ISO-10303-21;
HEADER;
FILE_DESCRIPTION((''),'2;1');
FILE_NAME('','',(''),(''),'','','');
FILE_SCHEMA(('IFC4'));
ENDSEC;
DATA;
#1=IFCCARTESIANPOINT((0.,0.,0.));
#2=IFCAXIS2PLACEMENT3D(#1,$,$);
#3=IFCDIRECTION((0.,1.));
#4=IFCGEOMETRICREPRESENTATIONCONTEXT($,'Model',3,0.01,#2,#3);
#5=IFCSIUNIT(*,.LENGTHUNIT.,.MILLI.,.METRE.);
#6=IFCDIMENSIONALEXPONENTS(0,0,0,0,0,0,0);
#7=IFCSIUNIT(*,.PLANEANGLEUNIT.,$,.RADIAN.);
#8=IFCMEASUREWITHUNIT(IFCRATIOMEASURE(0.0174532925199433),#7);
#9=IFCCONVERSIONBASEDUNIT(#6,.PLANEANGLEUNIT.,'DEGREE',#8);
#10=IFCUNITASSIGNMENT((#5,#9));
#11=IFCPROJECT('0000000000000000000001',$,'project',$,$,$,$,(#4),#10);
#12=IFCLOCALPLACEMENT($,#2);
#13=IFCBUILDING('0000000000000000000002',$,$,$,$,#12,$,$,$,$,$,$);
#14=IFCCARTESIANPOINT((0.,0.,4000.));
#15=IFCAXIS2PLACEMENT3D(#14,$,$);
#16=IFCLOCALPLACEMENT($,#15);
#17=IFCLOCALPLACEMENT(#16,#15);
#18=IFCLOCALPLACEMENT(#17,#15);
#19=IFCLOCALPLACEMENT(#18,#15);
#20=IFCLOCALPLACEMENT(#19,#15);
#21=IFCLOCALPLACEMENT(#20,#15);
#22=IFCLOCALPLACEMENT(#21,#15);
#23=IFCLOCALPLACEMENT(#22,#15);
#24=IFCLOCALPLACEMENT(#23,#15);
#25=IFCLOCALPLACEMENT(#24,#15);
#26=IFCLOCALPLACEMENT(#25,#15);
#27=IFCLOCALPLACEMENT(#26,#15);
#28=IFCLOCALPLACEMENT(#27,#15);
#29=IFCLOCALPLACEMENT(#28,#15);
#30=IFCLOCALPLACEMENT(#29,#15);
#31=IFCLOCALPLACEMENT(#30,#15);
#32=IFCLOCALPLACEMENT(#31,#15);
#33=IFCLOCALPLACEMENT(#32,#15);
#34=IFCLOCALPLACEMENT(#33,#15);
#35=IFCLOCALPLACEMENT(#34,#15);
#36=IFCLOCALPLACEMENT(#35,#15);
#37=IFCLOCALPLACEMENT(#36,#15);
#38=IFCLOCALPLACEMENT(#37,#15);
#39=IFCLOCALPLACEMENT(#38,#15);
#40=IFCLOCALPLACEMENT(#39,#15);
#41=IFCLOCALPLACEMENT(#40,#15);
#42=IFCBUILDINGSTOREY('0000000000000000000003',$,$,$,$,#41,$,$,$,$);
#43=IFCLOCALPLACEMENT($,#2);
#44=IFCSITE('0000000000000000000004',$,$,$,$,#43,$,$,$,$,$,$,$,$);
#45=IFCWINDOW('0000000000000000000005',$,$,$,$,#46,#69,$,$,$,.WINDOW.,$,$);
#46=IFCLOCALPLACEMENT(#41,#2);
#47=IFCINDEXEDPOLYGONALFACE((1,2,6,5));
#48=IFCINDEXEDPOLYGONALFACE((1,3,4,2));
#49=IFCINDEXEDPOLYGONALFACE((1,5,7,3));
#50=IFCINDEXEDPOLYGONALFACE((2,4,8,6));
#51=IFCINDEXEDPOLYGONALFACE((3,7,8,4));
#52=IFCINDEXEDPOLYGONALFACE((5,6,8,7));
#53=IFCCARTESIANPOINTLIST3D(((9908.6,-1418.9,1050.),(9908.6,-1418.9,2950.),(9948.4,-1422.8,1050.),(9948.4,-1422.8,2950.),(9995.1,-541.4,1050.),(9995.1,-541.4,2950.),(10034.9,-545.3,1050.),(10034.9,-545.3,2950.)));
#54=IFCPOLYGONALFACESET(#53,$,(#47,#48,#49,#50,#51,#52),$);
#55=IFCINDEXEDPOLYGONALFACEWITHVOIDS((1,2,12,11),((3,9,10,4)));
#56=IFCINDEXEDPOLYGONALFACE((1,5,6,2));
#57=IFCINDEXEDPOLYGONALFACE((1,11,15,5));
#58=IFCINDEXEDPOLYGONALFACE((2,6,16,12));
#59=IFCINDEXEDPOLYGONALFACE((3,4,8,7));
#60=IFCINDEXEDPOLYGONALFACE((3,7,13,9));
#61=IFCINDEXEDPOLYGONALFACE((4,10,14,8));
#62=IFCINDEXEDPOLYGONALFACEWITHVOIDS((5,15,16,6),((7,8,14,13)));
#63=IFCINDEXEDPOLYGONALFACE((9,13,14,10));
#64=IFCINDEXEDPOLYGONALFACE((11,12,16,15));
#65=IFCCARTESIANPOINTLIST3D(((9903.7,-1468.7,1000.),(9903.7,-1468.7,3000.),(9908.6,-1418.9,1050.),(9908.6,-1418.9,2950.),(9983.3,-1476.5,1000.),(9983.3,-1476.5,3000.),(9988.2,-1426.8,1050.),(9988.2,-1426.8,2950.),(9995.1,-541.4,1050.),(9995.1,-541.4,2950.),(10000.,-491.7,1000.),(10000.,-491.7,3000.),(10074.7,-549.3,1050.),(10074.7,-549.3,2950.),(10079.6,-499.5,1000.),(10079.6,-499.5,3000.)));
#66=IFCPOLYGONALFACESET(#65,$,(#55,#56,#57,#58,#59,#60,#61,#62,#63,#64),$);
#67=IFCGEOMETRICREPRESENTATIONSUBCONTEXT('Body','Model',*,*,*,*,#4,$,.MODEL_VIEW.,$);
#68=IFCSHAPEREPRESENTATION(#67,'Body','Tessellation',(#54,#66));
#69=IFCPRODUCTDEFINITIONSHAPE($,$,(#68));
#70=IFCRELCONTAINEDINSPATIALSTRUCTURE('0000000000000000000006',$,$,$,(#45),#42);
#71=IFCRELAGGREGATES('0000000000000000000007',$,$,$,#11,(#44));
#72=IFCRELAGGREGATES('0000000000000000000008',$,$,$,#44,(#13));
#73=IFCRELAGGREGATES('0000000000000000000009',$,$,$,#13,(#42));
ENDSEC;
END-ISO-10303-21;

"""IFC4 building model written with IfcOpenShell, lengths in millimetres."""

from ifc_helpers import new_model, entity, si_unit, converted_unit, direction, frame, origin, place, context, subcontext, project, spatial, element, save


model = new_model("IFC4")

# Units and contexts
model_context = context("Model", 3, precision=0.01, world=origin(), true_north=direction((0.0, 1.0)))
body_context = subcontext(model_context, "Body", "Model", "MODEL_VIEW")
ifc_project = project(units=[si_unit("LENGTHUNIT", "METRE", prefix="MILLI"), converted_unit("PLANEANGLEUNIT", "DEGREE", entity("IfcRatioMeasure", 0.0174532925199433), si_unit("PLANEANGLEUNIT", "RADIAN"), dimensions=[0, 0, 0, 0, 0, 0, 0])], contexts=[model_context])

# Site, building, storey
site_placement = place(None, origin())
site = spatial("IfcSite", under=ifc_project, at=site_placement)
building_placement = place(None, origin())
building = spatial("IfcBuilding", under=site, at=building_placement)
placement_1 = place(None, frame((0.0, 0.0, 4000.0)))
placement_2 = place(placement_1, frame((0.0, 0.0, 4000.0)))
placement_3 = place(placement_2, frame((0.0, 0.0, 4000.0)))
placement_4 = place(placement_3, frame((0.0, 0.0, 4000.0)))
placement_5 = place(placement_4, frame((0.0, 0.0, 4000.0)))
placement_6 = place(placement_5, frame((0.0, 0.0, 4000.0)))
placement_7 = place(placement_6, frame((0.0, 0.0, 4000.0)))
placement_8 = place(placement_7, frame((0.0, 0.0, 4000.0)))
placement_9 = place(placement_8, frame((0.0, 0.0, 4000.0)))
placement_10 = place(placement_9, frame((0.0, 0.0, 4000.0)))
placement_11 = place(placement_10, frame((0.0, 0.0, 4000.0)))
placement_12 = place(placement_11, frame((0.0, 0.0, 4000.0)))
placement_13 = place(placement_12, frame((0.0, 0.0, 4000.0)))
placement_14 = place(placement_13, frame((0.0, 0.0, 4000.0)))
placement_15 = place(placement_14, frame((0.0, 0.0, 4000.0)))
placement_16 = place(placement_15, frame((0.0, 0.0, 4000.0)))
placement_17 = place(placement_16, frame((0.0, 0.0, 4000.0)))
placement_18 = place(placement_17, frame((0.0, 0.0, 4000.0)))
placement_19 = place(placement_18, frame((0.0, 0.0, 4000.0)))
placement_20 = place(placement_19, frame((0.0, 0.0, 4000.0)))
placement_21 = place(placement_20, frame((0.0, 0.0, 4000.0)))
placement_22 = place(placement_21, frame((0.0, 0.0, 4000.0)))
placement_23 = place(placement_22, frame((0.0, 0.0, 4000.0)))
placement_24 = place(placement_23, frame((0.0, 0.0, 4000.0)))
placement_25 = place(placement_24, frame((0.0, 0.0, 4000.0)))
storey_placement = place(placement_25, frame((0.0, 0.0, 4000.0)))
storey = spatial("IfcBuildingStorey", under=building, at=storey_placement)

# Shared definitions
cartesian_point_1 = entity("IfcCartesianPoint", [-440.9, -950.0])
shared_polyline = entity("IfcPolyline", [cartesian_point_1, entity("IfcCartesianPoint", [-440.9, 950.0]), entity("IfcCartesianPoint", [-440.9, 950.0]), entity("IfcCartesianPoint", [440.9, 950.0]), entity("IfcCartesianPoint", [440.9, 950.0]), entity("IfcCartesianPoint", [440.9, -950.0]), entity("IfcCartesianPoint", [440.9, -950.0]), entity("IfcCartesianPoint", [-440.9, -950.0]), cartesian_point_1])

# Window
window_1_placement = place(storey_placement, frame((9951.8, -980.2, 2000.0), z_axis=(0.0, 0.0, 1.0), x_axis=(980.172434, 9951.847165, 0.0)))
cartesian_point_2 = entity("IfcCartesianPoint", [-490.9, -1000.0])
element("IfcWindow", 1, at=window_1_placement, inside=storey, PredefinedType="WINDOW", context=body_context, shape_type="SweptSolid", body=[
    entity("IfcExtrudedAreaSolid", entity("IfcArbitraryClosedProfileDef", "AREA", None, shared_polyline), entity("IfcAxis2Placement3D", entity("IfcCartesianPoint", [0.0, 0.0, 0.0]), entity("IfcDirection", [0.0, -1.0, 0.0]), entity("IfcDirection", [1.0, 0.0, 0.0])), entity("IfcDirection", [0.0, 0.0, 1.0]), 40.0),
    entity("IfcExtrudedAreaSolid", entity("IfcArbitraryProfileDefWithVoids", "AREA", None, entity("IfcPolyline", [cartesian_point_2, entity("IfcCartesianPoint", [-490.9, 1000.0]), entity("IfcCartesianPoint", [-490.9, 1000.0]), entity("IfcCartesianPoint", [490.9, 1000.0]), entity("IfcCartesianPoint", [490.9, 1000.0]), entity("IfcCartesianPoint", [490.9, -1000.0]), entity("IfcCartesianPoint", [490.9, -1000.0]), entity("IfcCartesianPoint", [-490.9, -1000.0]), cartesian_point_2]), [shared_polyline]), entity("IfcAxis2Placement3D", entity("IfcCartesianPoint", [0.0, 0.0, 0.0]), entity("IfcDirection", [0.0, -1.0, 0.0]), entity("IfcDirection", [1.0, 0.0, 0.0])), entity("IfcDirection", [0.0, 0.0, 1.0]), 80.0),
])

save(model, "model.ifc")
